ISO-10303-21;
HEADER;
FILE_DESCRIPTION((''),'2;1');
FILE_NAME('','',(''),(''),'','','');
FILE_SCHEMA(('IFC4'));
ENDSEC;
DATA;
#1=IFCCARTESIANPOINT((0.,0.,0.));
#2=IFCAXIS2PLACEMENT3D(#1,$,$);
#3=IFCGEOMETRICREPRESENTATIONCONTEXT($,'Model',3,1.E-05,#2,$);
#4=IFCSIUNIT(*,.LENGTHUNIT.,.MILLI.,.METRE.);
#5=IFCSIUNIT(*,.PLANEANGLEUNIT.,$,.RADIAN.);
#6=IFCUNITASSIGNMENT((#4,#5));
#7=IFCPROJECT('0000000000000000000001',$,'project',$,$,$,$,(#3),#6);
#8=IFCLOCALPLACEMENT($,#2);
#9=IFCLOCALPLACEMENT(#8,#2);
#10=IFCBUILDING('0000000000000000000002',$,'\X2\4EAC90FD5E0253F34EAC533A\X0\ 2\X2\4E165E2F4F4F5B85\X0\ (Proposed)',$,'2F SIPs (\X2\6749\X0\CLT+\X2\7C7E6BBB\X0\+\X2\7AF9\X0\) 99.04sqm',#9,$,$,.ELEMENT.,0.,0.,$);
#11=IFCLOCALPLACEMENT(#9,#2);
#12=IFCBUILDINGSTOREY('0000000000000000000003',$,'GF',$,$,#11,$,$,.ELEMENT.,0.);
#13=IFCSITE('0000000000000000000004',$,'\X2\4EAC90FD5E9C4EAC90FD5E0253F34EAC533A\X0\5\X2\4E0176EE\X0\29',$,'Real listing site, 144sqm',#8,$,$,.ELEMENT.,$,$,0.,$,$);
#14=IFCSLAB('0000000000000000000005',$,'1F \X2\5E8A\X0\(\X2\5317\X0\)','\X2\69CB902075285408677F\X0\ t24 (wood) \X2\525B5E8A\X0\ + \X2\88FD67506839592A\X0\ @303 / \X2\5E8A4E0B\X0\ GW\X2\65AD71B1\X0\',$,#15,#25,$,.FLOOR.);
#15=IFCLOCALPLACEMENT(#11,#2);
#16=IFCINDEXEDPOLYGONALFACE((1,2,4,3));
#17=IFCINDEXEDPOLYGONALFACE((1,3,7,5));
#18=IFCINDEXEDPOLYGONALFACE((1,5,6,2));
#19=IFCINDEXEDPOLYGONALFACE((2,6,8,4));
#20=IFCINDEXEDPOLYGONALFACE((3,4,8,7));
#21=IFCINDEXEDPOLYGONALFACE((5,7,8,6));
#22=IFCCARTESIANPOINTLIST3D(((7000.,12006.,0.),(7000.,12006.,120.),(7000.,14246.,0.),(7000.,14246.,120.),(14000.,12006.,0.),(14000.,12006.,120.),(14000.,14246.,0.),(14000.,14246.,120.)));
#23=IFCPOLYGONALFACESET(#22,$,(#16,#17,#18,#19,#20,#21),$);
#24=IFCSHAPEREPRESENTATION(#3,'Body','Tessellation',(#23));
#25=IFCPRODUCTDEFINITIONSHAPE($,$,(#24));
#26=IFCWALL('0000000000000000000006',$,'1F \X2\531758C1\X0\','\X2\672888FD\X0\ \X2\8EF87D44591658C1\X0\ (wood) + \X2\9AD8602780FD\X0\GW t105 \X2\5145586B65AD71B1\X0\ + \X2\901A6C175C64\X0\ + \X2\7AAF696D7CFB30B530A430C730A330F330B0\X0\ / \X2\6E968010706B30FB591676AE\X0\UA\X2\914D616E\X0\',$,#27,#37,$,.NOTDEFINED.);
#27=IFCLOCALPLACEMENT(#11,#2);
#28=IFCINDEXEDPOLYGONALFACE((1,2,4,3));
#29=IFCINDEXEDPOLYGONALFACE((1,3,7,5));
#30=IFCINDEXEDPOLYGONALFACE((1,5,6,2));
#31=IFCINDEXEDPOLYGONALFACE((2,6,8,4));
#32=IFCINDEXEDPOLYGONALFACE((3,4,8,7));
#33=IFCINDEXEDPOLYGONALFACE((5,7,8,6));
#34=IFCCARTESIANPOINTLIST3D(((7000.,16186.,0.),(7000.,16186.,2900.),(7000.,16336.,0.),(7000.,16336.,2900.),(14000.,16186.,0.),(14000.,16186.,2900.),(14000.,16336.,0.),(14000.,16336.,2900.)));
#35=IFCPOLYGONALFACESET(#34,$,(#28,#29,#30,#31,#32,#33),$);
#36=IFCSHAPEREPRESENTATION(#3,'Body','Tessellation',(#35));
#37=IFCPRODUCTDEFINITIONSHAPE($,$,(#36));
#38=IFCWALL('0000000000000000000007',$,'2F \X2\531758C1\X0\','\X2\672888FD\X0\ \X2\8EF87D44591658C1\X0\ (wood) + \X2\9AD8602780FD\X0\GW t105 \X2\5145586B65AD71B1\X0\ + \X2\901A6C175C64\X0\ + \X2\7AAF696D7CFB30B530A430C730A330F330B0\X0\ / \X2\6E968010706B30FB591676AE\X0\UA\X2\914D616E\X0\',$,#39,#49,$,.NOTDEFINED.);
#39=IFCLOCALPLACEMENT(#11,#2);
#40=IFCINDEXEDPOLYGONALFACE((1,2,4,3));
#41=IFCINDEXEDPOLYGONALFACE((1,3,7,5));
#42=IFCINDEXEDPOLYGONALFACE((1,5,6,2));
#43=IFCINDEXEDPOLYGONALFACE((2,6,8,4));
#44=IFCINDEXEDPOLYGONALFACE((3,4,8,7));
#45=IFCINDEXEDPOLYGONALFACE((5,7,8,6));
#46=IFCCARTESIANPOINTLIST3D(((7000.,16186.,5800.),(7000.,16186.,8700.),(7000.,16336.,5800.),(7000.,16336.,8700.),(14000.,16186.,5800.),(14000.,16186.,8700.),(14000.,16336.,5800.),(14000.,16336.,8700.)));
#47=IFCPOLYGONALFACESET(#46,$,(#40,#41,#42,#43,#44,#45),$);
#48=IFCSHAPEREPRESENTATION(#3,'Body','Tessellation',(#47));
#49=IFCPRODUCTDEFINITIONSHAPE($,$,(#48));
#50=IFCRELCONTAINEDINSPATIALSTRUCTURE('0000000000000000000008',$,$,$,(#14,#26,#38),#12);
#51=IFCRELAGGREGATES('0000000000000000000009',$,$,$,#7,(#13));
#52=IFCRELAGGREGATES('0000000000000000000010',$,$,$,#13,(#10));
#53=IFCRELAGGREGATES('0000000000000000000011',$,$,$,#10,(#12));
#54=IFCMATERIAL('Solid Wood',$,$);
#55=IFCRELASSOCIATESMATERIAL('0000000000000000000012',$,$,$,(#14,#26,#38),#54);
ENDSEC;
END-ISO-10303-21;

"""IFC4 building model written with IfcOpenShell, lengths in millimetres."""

from ifc_helpers import new_model, si_unit, frame, frame_2d, origin, place, context, project, spatial, rectangle, extrude, material, element, save


model = new_model("IFC4")

# Units and contexts
model_context = context("Model", 3, precision=1e-05, world=origin())
ifc_project = project(units=[si_unit("LENGTHUNIT", "METRE", prefix="MILLI"), si_unit("PLANEANGLEUNIT", "RADIAN")], contexts=[model_context])

# Site, building, storey
site_placement = place(None, origin())
site = spatial("IfcSite", under=ifc_project, at=site_placement, Name="京都府京都市右京区5丁目29", ObjectType="Real listing site, 144sqm", CompositionType="ELEMENT", RefElevation=0.0)
building_placement = place(site_placement, origin())
building = spatial("IfcBuilding", under=site, at=building_placement, Name="京都市右京区 2世帯住宅 (Proposed)", ObjectType="2F SIPs (杉CLT+籾殻+竹) 99.04sqm", CompositionType="ELEMENT", ElevationOfRefHeight=0.0, ElevationOfTerrain=0.0)
storey_placement = place(building_placement, origin())
storey = spatial("IfcBuildingStorey", under=building, at=storey_placement, Name="GF", CompositionType="ELEMENT", Elevation=0.0)

# Slab
ifc_material_1 = material(Name="Solid Wood")
slab_1_placement = place(storey_placement, frame((3500.0, 6003.0, 0.0)))
element("IfcSlab", 1, at=slab_1_placement, inside=storey, material=ifc_material_1, Name="1F 床(北)", Description="構造用合板 t24 (wood) 剛床 + 製材根太 @303 / 床下 GW断熱", PredefinedType="FLOOR", context=model_context, shape_type="SweptSolid", body=[
    extrude(rectangle(XDim=7000.0, YDim=2240.0, at=frame_2d((3500.0, 1120.0))), frame((3500.0, 6003.0, 0.0)), (0.0, 0.0, 1.0), 120.0),
])

# Wall
wall_1_placement = place(storey_placement, frame((3500.0, 8093.0, 0.0)))
element("IfcWall", 2, at=wall_1_placement, inside=storey, material=ifc_material_1, Name="1F 北壁", Description="木製 軸組外壁 (wood) + 高性能GW t105 充填断熱 + 通気層 + 窯業系サイディング / 準耐火・外皮UA配慮", PredefinedType="NOTDEFINED", context=model_context, shape_type="SweptSolid", body=[
    extrude(rectangle(XDim=7000.0, YDim=150.0, at=frame_2d((3500.0, 75.0))), frame((3500.0, 8093.0, 0.0)), (0.0, 0.0, 1.0), 2900.0),
])

# Wall
wall_2_placement = place(storey_placement, frame((3500.0, 8093.0, 2900.0)))
element("IfcWall", 3, at=wall_2_placement, inside=storey, material=ifc_material_1, Name="2F 北壁", Description="木製 軸組外壁 (wood) + 高性能GW t105 充填断熱 + 通気層 + 窯業系サイディング / 準耐火・外皮UA配慮", PredefinedType="NOTDEFINED", context=model_context, shape_type="SweptSolid", body=[
    extrude(rectangle(XDim=7000.0, YDim=150.0, at=frame_2d((3500.0, 75.0))), frame((3500.0, 8093.0, 2900.0)), (0.0, 0.0, 1.0), 2900.0),
])

save(model, "model.ifc")
